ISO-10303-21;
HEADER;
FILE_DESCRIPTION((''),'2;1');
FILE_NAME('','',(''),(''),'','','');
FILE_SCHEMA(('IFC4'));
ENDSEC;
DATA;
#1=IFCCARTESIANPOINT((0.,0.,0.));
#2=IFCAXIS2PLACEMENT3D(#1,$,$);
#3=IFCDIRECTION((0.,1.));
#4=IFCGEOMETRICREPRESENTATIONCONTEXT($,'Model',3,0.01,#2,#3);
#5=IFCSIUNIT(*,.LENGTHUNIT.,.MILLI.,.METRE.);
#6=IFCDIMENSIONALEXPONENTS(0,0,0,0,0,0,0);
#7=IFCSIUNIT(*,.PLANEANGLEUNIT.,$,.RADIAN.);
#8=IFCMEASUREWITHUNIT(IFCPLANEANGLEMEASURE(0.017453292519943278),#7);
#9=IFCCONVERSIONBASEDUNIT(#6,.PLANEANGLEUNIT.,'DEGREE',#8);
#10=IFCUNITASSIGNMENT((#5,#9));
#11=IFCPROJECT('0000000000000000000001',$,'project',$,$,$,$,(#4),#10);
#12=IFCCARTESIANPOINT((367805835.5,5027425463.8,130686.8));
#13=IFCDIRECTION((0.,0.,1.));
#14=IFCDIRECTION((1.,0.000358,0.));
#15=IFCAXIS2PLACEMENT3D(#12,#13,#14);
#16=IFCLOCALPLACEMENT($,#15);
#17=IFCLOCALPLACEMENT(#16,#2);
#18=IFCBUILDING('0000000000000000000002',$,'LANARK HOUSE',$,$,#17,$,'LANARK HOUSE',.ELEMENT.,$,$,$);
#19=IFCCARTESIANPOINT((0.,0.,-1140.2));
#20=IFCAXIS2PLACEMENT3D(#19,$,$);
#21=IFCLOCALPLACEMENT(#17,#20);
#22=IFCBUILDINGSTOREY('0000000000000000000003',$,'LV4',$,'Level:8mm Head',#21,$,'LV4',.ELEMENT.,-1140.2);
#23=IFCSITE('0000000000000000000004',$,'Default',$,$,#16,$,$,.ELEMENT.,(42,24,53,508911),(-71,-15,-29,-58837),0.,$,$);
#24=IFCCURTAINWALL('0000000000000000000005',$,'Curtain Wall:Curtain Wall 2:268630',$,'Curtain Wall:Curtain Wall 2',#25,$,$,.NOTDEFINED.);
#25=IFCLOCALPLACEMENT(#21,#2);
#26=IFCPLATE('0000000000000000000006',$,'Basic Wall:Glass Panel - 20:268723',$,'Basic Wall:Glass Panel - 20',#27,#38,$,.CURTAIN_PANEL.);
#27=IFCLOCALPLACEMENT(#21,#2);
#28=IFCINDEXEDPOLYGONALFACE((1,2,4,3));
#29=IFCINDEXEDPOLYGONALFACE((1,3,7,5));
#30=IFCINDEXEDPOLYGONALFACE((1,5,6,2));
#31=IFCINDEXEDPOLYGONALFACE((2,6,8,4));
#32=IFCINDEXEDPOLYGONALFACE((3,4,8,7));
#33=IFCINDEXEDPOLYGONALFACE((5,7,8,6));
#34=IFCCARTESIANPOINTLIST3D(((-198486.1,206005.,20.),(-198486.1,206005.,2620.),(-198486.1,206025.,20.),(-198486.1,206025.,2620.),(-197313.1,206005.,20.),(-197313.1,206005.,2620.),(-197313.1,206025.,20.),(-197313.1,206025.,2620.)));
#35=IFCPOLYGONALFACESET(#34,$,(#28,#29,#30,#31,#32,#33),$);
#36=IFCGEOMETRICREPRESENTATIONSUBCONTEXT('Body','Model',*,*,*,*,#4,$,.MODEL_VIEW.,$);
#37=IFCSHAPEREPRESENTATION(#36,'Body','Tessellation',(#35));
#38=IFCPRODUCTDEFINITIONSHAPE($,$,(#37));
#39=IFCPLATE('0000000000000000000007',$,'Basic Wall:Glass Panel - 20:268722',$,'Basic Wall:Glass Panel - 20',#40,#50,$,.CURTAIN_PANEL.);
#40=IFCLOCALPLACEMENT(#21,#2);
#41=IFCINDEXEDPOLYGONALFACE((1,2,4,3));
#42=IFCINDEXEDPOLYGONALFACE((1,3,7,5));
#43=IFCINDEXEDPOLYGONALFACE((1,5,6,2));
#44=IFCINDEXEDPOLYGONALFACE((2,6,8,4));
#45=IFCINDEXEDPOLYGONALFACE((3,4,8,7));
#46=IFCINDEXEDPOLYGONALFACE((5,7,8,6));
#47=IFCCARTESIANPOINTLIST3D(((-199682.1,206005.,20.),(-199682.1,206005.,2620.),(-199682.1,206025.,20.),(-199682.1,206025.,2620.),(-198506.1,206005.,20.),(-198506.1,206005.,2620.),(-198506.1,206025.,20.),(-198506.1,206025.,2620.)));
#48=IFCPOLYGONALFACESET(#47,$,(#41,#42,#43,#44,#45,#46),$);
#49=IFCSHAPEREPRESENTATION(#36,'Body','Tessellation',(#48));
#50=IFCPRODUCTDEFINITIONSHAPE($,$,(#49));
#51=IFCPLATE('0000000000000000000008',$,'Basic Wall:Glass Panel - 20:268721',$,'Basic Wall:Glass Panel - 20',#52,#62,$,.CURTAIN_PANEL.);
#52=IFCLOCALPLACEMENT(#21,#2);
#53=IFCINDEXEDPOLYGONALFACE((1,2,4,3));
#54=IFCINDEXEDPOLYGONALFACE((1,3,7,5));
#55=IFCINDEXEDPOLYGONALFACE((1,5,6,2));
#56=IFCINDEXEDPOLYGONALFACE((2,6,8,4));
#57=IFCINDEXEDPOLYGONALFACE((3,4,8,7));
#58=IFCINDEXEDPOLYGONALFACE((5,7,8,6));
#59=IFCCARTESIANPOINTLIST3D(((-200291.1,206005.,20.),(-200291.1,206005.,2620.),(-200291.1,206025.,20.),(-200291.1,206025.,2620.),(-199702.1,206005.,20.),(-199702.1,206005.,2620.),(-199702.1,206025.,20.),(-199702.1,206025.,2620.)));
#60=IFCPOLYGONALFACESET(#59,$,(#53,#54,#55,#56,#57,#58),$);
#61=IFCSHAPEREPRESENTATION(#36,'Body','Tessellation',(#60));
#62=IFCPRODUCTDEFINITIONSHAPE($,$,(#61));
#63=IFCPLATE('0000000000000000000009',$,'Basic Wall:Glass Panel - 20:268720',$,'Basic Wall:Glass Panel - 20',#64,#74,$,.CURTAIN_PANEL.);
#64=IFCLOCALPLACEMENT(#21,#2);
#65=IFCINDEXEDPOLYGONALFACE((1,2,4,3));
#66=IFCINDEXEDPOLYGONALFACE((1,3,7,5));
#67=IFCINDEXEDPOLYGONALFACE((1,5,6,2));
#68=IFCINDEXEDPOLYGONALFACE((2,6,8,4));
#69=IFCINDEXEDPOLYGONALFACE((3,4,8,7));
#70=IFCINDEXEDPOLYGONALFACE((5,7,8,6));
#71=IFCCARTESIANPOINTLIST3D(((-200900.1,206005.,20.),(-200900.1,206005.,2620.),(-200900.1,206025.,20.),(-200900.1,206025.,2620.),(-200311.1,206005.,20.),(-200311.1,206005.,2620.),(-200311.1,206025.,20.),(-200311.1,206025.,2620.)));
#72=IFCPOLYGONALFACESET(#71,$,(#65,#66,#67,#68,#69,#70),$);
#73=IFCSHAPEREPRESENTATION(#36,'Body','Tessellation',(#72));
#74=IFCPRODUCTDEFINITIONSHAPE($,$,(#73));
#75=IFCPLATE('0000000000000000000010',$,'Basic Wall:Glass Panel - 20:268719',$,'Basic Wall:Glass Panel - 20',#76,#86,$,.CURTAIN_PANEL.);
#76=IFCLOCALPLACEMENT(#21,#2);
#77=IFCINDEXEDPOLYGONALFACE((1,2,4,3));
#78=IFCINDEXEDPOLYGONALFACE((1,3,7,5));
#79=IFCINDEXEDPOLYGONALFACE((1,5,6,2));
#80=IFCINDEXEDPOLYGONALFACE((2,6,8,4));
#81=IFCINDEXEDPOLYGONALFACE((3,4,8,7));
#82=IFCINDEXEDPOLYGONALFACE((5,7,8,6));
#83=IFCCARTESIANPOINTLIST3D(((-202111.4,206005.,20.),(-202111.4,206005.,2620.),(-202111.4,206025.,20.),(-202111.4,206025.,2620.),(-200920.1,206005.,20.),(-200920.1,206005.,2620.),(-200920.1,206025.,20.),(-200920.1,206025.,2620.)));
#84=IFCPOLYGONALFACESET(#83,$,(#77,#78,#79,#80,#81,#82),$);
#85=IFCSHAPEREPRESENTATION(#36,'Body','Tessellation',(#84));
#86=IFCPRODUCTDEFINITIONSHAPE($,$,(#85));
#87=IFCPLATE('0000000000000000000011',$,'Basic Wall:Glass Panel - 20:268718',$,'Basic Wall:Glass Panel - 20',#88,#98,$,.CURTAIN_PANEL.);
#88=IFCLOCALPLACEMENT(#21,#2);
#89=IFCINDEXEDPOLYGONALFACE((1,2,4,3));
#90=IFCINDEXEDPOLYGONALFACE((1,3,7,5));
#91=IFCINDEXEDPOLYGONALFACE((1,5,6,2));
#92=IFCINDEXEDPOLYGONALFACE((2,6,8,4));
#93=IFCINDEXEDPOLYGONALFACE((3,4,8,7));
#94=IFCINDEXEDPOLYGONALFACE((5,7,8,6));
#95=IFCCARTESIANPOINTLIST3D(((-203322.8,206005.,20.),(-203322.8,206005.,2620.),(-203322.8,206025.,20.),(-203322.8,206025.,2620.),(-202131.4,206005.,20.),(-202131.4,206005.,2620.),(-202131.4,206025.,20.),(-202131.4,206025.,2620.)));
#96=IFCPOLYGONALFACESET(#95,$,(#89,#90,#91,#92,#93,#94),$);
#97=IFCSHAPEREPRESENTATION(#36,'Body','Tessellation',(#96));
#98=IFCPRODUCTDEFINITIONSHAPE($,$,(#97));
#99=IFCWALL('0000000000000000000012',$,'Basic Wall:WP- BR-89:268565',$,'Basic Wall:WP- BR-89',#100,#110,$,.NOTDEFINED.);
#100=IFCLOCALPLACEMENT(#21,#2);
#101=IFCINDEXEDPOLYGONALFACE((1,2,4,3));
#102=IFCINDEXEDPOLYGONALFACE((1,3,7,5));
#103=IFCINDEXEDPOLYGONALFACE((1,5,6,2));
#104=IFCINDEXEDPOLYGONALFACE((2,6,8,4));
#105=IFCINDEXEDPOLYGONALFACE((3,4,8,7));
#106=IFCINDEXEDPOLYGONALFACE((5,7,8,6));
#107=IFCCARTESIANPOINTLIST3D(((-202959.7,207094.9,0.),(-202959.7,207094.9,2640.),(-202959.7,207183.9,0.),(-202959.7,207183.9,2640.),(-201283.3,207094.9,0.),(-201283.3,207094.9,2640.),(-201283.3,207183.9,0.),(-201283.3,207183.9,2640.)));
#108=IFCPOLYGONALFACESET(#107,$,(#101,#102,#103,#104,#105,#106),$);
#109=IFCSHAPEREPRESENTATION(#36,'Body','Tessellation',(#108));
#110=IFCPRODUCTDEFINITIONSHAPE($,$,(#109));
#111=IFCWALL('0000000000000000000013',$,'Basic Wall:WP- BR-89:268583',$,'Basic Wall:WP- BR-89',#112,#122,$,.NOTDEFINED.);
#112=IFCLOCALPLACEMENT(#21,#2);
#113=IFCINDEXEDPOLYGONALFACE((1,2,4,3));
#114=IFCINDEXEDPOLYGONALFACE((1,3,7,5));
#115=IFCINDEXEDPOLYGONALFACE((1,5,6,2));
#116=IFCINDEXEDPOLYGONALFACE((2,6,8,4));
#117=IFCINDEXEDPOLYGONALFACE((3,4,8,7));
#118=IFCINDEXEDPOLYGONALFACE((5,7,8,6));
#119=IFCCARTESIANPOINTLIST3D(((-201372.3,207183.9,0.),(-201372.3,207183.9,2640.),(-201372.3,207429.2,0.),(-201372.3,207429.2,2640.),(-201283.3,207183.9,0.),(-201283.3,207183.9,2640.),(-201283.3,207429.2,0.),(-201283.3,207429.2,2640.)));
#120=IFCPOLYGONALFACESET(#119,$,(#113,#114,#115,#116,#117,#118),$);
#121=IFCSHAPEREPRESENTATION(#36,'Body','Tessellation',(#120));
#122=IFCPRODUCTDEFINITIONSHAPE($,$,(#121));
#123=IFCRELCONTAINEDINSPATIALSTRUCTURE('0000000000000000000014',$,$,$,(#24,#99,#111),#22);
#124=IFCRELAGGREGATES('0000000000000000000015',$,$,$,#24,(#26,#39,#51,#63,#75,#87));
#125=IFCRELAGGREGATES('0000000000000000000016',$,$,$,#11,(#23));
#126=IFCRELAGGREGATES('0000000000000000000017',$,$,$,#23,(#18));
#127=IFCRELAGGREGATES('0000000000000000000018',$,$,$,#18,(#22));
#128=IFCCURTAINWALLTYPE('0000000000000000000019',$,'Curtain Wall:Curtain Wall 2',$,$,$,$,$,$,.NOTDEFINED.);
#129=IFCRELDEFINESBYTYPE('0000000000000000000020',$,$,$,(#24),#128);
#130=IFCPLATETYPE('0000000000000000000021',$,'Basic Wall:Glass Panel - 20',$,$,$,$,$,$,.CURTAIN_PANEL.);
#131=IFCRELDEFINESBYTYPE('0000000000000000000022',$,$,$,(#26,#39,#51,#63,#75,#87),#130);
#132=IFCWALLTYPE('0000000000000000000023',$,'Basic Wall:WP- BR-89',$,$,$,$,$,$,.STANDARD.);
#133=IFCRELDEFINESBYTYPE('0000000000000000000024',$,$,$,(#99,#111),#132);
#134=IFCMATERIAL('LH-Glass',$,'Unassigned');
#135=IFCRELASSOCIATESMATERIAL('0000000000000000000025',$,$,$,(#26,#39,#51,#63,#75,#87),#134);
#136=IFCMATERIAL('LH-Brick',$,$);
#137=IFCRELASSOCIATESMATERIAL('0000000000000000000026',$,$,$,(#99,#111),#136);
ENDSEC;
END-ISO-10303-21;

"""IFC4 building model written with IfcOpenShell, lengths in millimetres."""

from ifc_helpers import new_model, entity, si_unit, converted_unit, direction, frame, origin, place, context, subcontext, project, spatial, indexed_curve, outline, extrude, material, type_object, element, aggregate, save


model = new_model("IFC4")

# Units and contexts
model_context = context("Model", 3, precision=0.01, world=origin(), true_north=direction((0.0, 1.0)))
body_context = subcontext(model_context, "Body", "Model", "MODEL_VIEW")
ifc_project = project(units=[si_unit("LENGTHUNIT", "METRE", prefix="MILLI"), converted_unit("PLANEANGLEUNIT", "DEGREE", entity("IfcPlaneAngleMeasure", 0.017453292519943278), si_unit("PLANEANGLEUNIT", "RADIAN"), dimensions=[0, 0, 0, 0, 0, 0, 0])], contexts=[model_context])

# Site, building, storey
site_placement = place(None, frame((367805835.5, 5027425463.8, 130686.8), z_axis=(0.0, 0.0, 1.0), x_axis=(1.0, 0.000358, 0.0)))
site = spatial("IfcSite", under=ifc_project, at=site_placement, Name="Default", CompositionType="ELEMENT", RefLatitude=(42, 24, 53, 508911), RefLongitude=(-71, -15, -29, -58837), RefElevation=0.0)
building_placement = place(site_placement, origin())
building = spatial("IfcBuilding", under=site, at=building_placement, Name="LANARK HOUSE", LongName="LANARK HOUSE", CompositionType="ELEMENT")
storey_placement = place(building_placement, frame((0.0, 0.0, -1140.2)))
storey = spatial("IfcBuildingStorey", under=building, at=storey_placement, Name="LV4", ObjectType="Level:8mm Head", LongName="LV4", CompositionType="ELEMENT", Elevation=-1140.2)

# Curtain wall, plates
curtain_wall_type = type_object("IfcCurtainWallType", Name="Curtain Wall:Curtain Wall 2", PredefinedType="NOTDEFINED")
curtain_wall_placement = place(storey_placement, frame((0.0, 0.0, 1140.2)))
curtain_wall = element("IfcCurtainWall", 1, at=curtain_wall_placement, inside=storey, type_object=curtain_wall_type, Name="Curtain Wall:Curtain Wall 2:268630", ObjectType="Curtain Wall:Curtain Wall 2", PredefinedType="NOTDEFINED")
ifc_material_1 = material(Name="LH-Glass", Category="Unassigned")
plate_type = type_object("IfcPlateType", Name="Basic Wall:Glass Panel - 20", PredefinedType="CURTAIN_PANEL")
plate_1_placement = place(storey_placement, frame((-197313.1, 206015.0, 20.0), z_axis=(0.0, 0.0, 1.0), x_axis=(-1.0, 0.0, 0.0)))
plate_1 = element("IfcPlate", 2, at=plate_1_placement, type_object=plate_type, material=ifc_material_1, Name="Basic Wall:Glass Panel - 20:268723", ObjectType="Basic Wall:Glass Panel - 20", PredefinedType="CURTAIN_PANEL", context=body_context, shape_type="SweptSolid", body=[
    extrude(outline(indexed_curve([(-10.0, -586.5), (10.0, -586.5), (10.0, 586.5), (-10.0, 586.5), (-10.0, -586.5)], self_intersect=False)), frame((586.5, 0.0, 0.0), z_axis=(0.0, 0.0, 1.0), x_axis=(0.0, 1.0, 0.0)), (0.0, 0.0, 1.0), 2600.0),
])
plate_2_placement = place(storey_placement, frame((-198506.1, 206015.0, 20.0), z_axis=(0.0, 0.0, 1.0), x_axis=(-1.0, 0.0, 0.0)))
plate_2 = element("IfcPlate", 3, at=plate_2_placement, type_object=plate_type, material=ifc_material_1, Name="Basic Wall:Glass Panel - 20:268722", ObjectType="Basic Wall:Glass Panel - 20", PredefinedType="CURTAIN_PANEL", context=body_context, shape_type="SweptSolid", body=[
    extrude(outline(indexed_curve([(-10.0, -588.0), (10.0, -588.0), (10.0, 588.0), (-10.0, 588.0), (-10.0, -588.0)], self_intersect=False)), frame((588.0, 0.0, 0.0), z_axis=(0.0, 0.0, 1.0), x_axis=(0.0, 1.0, 0.0)), (0.0, 0.0, 1.0), 2600.0),
])
plate_3_placement = place(storey_placement, frame((-199702.1, 206015.0, 20.0), z_axis=(0.0, 0.0, 1.0), x_axis=(-1.0, 0.0, 0.0)))
plate_3 = element("IfcPlate", 4, at=plate_3_placement, type_object=plate_type, material=ifc_material_1, Name="Basic Wall:Glass Panel - 20:268721", ObjectType="Basic Wall:Glass Panel - 20", PredefinedType="CURTAIN_PANEL", context=body_context, shape_type="SweptSolid", body=[
    extrude(outline(indexed_curve([(-10.0, -294.5), (10.0, -294.5), (10.0, 294.5), (-10.0, 294.5), (-10.0, -294.5)], self_intersect=False)), frame((294.5, 0.0, 0.0), z_axis=(0.0, 0.0, 1.0), x_axis=(0.0, 1.0, 0.0)), (0.0, 0.0, 1.0), 2600.0),
])
plate_4_placement = place(storey_placement, frame((-200311.1, 206015.0, 20.0), z_axis=(0.0, 0.0, 1.0), x_axis=(-1.0, 0.0, 0.0)))
plate_4 = element("IfcPlate", 5, at=plate_4_placement, type_object=plate_type, material=ifc_material_1, Name="Basic Wall:Glass Panel - 20:268720", ObjectType="Basic Wall:Glass Panel - 20", PredefinedType="CURTAIN_PANEL", context=body_context, shape_type="SweptSolid", body=[
    extrude(outline(indexed_curve([(-10.0, -294.5), (10.0, -294.5), (10.0, 294.5), (-10.0, 294.5), (-10.0, -294.5)], self_intersect=False)), frame((294.5, 0.0, 0.0), z_axis=(0.0, 0.0, 1.0), x_axis=(0.0, 1.0, 0.0)), (0.0, 0.0, 1.0), 2600.0),
])
plate_5_placement = place(storey_placement, frame((-200920.1, 206015.0, 20.0), z_axis=(0.0, 0.0, 1.0), x_axis=(-1.0, 0.0, 0.0)))
plate_5 = element("IfcPlate", 6, at=plate_5_placement, type_object=plate_type, material=ifc_material_1, Name="Basic Wall:Glass Panel - 20:268719", ObjectType="Basic Wall:Glass Panel - 20", PredefinedType="CURTAIN_PANEL", context=body_context, shape_type="SweptSolid", body=[
    extrude(outline(indexed_curve([(-10.0, -595.6), (10.0, -595.6), (10.0, 595.6), (-10.0, 595.6), (-10.0, -595.6)], self_intersect=False)), frame((595.6, 0.0, 0.0), z_axis=(0.0, 0.0, 1.0), x_axis=(0.0, 1.0, 0.0)), (0.0, 0.0, 1.0), 2600.0),
])
plate_6_placement = place(storey_placement, frame((-202131.4, 206015.0, 20.0), z_axis=(0.0, 0.0, 1.0), x_axis=(-1.0, 0.0, 0.0)))
plate_6 = element("IfcPlate", 7, at=plate_6_placement, type_object=plate_type, material=ifc_material_1, Name="Basic Wall:Glass Panel - 20:268718", ObjectType="Basic Wall:Glass Panel - 20", PredefinedType="CURTAIN_PANEL", context=body_context, shape_type="SweptSolid", body=[
    extrude(outline(indexed_curve([(-10.0, -595.7), (10.0, -595.7), (10.0, 595.7), (-10.0, 595.7), (-10.0, -595.7)], self_intersect=False)), frame((595.7, 0.0, 0.0), z_axis=(0.0, 0.0, 1.0), x_axis=(0.0, 1.0, 0.0)), (0.0, 0.0, 1.0), 2600.0),
])
aggregate(curtain_wall, [plate_1, plate_2, plate_3, plate_4, plate_5, plate_6])

# Walls
ifc_material_2 = material(Name="LH-Brick")
wall_type_1 = type_object("IfcWallType", Name="Basic Wall:WP- BR-89", PredefinedType="STANDARD")
wall_1_placement = place(storey_placement, frame((-201283.3, 207139.4, 0.0), z_axis=(0.0, 0.0, 1.0), x_axis=(-1.0, 0.0, 0.0)))
element("IfcWall", 8, at=wall_1_placement, inside=storey, type_object=wall_type_1, material=ifc_material_2, Name="Basic Wall:WP- BR-89:268565", ObjectType="Basic Wall:WP- BR-89", PredefinedType="NOTDEFINED", context=body_context, shape_type="SweptSolid", body=[
    extrude(outline(indexed_curve([(1676.4, 44.5), (0.0, 44.5), (0.0, -44.5), (1676.4, -44.5), (1676.4, 44.5)], self_intersect=False)), origin(), (0.0, 0.0, 1.0), 2640.0),
])
wall_2_placement = place(storey_placement, frame((-201327.8, 207429.2, 0.0), z_axis=(0.0, 0.0, 1.0), x_axis=(0.0, -1.0, 0.0)))
element("IfcWall", 9, at=wall_2_placement, inside=storey, type_object=wall_type_1, material=ifc_material_2, Name="Basic Wall:WP- BR-89:268583", ObjectType="Basic Wall:WP- BR-89", PredefinedType="NOTDEFINED", context=body_context, shape_type="SweptSolid", body=[
    extrude(outline(indexed_curve([(245.3, 44.5), (0.0, 44.5), (0.0, -44.5), (245.3, -44.5), (245.3, 44.5)], self_intersect=False)), origin(), (0.0, 0.0, 1.0), 2640.0),
])

save(model, "model.ifc")
